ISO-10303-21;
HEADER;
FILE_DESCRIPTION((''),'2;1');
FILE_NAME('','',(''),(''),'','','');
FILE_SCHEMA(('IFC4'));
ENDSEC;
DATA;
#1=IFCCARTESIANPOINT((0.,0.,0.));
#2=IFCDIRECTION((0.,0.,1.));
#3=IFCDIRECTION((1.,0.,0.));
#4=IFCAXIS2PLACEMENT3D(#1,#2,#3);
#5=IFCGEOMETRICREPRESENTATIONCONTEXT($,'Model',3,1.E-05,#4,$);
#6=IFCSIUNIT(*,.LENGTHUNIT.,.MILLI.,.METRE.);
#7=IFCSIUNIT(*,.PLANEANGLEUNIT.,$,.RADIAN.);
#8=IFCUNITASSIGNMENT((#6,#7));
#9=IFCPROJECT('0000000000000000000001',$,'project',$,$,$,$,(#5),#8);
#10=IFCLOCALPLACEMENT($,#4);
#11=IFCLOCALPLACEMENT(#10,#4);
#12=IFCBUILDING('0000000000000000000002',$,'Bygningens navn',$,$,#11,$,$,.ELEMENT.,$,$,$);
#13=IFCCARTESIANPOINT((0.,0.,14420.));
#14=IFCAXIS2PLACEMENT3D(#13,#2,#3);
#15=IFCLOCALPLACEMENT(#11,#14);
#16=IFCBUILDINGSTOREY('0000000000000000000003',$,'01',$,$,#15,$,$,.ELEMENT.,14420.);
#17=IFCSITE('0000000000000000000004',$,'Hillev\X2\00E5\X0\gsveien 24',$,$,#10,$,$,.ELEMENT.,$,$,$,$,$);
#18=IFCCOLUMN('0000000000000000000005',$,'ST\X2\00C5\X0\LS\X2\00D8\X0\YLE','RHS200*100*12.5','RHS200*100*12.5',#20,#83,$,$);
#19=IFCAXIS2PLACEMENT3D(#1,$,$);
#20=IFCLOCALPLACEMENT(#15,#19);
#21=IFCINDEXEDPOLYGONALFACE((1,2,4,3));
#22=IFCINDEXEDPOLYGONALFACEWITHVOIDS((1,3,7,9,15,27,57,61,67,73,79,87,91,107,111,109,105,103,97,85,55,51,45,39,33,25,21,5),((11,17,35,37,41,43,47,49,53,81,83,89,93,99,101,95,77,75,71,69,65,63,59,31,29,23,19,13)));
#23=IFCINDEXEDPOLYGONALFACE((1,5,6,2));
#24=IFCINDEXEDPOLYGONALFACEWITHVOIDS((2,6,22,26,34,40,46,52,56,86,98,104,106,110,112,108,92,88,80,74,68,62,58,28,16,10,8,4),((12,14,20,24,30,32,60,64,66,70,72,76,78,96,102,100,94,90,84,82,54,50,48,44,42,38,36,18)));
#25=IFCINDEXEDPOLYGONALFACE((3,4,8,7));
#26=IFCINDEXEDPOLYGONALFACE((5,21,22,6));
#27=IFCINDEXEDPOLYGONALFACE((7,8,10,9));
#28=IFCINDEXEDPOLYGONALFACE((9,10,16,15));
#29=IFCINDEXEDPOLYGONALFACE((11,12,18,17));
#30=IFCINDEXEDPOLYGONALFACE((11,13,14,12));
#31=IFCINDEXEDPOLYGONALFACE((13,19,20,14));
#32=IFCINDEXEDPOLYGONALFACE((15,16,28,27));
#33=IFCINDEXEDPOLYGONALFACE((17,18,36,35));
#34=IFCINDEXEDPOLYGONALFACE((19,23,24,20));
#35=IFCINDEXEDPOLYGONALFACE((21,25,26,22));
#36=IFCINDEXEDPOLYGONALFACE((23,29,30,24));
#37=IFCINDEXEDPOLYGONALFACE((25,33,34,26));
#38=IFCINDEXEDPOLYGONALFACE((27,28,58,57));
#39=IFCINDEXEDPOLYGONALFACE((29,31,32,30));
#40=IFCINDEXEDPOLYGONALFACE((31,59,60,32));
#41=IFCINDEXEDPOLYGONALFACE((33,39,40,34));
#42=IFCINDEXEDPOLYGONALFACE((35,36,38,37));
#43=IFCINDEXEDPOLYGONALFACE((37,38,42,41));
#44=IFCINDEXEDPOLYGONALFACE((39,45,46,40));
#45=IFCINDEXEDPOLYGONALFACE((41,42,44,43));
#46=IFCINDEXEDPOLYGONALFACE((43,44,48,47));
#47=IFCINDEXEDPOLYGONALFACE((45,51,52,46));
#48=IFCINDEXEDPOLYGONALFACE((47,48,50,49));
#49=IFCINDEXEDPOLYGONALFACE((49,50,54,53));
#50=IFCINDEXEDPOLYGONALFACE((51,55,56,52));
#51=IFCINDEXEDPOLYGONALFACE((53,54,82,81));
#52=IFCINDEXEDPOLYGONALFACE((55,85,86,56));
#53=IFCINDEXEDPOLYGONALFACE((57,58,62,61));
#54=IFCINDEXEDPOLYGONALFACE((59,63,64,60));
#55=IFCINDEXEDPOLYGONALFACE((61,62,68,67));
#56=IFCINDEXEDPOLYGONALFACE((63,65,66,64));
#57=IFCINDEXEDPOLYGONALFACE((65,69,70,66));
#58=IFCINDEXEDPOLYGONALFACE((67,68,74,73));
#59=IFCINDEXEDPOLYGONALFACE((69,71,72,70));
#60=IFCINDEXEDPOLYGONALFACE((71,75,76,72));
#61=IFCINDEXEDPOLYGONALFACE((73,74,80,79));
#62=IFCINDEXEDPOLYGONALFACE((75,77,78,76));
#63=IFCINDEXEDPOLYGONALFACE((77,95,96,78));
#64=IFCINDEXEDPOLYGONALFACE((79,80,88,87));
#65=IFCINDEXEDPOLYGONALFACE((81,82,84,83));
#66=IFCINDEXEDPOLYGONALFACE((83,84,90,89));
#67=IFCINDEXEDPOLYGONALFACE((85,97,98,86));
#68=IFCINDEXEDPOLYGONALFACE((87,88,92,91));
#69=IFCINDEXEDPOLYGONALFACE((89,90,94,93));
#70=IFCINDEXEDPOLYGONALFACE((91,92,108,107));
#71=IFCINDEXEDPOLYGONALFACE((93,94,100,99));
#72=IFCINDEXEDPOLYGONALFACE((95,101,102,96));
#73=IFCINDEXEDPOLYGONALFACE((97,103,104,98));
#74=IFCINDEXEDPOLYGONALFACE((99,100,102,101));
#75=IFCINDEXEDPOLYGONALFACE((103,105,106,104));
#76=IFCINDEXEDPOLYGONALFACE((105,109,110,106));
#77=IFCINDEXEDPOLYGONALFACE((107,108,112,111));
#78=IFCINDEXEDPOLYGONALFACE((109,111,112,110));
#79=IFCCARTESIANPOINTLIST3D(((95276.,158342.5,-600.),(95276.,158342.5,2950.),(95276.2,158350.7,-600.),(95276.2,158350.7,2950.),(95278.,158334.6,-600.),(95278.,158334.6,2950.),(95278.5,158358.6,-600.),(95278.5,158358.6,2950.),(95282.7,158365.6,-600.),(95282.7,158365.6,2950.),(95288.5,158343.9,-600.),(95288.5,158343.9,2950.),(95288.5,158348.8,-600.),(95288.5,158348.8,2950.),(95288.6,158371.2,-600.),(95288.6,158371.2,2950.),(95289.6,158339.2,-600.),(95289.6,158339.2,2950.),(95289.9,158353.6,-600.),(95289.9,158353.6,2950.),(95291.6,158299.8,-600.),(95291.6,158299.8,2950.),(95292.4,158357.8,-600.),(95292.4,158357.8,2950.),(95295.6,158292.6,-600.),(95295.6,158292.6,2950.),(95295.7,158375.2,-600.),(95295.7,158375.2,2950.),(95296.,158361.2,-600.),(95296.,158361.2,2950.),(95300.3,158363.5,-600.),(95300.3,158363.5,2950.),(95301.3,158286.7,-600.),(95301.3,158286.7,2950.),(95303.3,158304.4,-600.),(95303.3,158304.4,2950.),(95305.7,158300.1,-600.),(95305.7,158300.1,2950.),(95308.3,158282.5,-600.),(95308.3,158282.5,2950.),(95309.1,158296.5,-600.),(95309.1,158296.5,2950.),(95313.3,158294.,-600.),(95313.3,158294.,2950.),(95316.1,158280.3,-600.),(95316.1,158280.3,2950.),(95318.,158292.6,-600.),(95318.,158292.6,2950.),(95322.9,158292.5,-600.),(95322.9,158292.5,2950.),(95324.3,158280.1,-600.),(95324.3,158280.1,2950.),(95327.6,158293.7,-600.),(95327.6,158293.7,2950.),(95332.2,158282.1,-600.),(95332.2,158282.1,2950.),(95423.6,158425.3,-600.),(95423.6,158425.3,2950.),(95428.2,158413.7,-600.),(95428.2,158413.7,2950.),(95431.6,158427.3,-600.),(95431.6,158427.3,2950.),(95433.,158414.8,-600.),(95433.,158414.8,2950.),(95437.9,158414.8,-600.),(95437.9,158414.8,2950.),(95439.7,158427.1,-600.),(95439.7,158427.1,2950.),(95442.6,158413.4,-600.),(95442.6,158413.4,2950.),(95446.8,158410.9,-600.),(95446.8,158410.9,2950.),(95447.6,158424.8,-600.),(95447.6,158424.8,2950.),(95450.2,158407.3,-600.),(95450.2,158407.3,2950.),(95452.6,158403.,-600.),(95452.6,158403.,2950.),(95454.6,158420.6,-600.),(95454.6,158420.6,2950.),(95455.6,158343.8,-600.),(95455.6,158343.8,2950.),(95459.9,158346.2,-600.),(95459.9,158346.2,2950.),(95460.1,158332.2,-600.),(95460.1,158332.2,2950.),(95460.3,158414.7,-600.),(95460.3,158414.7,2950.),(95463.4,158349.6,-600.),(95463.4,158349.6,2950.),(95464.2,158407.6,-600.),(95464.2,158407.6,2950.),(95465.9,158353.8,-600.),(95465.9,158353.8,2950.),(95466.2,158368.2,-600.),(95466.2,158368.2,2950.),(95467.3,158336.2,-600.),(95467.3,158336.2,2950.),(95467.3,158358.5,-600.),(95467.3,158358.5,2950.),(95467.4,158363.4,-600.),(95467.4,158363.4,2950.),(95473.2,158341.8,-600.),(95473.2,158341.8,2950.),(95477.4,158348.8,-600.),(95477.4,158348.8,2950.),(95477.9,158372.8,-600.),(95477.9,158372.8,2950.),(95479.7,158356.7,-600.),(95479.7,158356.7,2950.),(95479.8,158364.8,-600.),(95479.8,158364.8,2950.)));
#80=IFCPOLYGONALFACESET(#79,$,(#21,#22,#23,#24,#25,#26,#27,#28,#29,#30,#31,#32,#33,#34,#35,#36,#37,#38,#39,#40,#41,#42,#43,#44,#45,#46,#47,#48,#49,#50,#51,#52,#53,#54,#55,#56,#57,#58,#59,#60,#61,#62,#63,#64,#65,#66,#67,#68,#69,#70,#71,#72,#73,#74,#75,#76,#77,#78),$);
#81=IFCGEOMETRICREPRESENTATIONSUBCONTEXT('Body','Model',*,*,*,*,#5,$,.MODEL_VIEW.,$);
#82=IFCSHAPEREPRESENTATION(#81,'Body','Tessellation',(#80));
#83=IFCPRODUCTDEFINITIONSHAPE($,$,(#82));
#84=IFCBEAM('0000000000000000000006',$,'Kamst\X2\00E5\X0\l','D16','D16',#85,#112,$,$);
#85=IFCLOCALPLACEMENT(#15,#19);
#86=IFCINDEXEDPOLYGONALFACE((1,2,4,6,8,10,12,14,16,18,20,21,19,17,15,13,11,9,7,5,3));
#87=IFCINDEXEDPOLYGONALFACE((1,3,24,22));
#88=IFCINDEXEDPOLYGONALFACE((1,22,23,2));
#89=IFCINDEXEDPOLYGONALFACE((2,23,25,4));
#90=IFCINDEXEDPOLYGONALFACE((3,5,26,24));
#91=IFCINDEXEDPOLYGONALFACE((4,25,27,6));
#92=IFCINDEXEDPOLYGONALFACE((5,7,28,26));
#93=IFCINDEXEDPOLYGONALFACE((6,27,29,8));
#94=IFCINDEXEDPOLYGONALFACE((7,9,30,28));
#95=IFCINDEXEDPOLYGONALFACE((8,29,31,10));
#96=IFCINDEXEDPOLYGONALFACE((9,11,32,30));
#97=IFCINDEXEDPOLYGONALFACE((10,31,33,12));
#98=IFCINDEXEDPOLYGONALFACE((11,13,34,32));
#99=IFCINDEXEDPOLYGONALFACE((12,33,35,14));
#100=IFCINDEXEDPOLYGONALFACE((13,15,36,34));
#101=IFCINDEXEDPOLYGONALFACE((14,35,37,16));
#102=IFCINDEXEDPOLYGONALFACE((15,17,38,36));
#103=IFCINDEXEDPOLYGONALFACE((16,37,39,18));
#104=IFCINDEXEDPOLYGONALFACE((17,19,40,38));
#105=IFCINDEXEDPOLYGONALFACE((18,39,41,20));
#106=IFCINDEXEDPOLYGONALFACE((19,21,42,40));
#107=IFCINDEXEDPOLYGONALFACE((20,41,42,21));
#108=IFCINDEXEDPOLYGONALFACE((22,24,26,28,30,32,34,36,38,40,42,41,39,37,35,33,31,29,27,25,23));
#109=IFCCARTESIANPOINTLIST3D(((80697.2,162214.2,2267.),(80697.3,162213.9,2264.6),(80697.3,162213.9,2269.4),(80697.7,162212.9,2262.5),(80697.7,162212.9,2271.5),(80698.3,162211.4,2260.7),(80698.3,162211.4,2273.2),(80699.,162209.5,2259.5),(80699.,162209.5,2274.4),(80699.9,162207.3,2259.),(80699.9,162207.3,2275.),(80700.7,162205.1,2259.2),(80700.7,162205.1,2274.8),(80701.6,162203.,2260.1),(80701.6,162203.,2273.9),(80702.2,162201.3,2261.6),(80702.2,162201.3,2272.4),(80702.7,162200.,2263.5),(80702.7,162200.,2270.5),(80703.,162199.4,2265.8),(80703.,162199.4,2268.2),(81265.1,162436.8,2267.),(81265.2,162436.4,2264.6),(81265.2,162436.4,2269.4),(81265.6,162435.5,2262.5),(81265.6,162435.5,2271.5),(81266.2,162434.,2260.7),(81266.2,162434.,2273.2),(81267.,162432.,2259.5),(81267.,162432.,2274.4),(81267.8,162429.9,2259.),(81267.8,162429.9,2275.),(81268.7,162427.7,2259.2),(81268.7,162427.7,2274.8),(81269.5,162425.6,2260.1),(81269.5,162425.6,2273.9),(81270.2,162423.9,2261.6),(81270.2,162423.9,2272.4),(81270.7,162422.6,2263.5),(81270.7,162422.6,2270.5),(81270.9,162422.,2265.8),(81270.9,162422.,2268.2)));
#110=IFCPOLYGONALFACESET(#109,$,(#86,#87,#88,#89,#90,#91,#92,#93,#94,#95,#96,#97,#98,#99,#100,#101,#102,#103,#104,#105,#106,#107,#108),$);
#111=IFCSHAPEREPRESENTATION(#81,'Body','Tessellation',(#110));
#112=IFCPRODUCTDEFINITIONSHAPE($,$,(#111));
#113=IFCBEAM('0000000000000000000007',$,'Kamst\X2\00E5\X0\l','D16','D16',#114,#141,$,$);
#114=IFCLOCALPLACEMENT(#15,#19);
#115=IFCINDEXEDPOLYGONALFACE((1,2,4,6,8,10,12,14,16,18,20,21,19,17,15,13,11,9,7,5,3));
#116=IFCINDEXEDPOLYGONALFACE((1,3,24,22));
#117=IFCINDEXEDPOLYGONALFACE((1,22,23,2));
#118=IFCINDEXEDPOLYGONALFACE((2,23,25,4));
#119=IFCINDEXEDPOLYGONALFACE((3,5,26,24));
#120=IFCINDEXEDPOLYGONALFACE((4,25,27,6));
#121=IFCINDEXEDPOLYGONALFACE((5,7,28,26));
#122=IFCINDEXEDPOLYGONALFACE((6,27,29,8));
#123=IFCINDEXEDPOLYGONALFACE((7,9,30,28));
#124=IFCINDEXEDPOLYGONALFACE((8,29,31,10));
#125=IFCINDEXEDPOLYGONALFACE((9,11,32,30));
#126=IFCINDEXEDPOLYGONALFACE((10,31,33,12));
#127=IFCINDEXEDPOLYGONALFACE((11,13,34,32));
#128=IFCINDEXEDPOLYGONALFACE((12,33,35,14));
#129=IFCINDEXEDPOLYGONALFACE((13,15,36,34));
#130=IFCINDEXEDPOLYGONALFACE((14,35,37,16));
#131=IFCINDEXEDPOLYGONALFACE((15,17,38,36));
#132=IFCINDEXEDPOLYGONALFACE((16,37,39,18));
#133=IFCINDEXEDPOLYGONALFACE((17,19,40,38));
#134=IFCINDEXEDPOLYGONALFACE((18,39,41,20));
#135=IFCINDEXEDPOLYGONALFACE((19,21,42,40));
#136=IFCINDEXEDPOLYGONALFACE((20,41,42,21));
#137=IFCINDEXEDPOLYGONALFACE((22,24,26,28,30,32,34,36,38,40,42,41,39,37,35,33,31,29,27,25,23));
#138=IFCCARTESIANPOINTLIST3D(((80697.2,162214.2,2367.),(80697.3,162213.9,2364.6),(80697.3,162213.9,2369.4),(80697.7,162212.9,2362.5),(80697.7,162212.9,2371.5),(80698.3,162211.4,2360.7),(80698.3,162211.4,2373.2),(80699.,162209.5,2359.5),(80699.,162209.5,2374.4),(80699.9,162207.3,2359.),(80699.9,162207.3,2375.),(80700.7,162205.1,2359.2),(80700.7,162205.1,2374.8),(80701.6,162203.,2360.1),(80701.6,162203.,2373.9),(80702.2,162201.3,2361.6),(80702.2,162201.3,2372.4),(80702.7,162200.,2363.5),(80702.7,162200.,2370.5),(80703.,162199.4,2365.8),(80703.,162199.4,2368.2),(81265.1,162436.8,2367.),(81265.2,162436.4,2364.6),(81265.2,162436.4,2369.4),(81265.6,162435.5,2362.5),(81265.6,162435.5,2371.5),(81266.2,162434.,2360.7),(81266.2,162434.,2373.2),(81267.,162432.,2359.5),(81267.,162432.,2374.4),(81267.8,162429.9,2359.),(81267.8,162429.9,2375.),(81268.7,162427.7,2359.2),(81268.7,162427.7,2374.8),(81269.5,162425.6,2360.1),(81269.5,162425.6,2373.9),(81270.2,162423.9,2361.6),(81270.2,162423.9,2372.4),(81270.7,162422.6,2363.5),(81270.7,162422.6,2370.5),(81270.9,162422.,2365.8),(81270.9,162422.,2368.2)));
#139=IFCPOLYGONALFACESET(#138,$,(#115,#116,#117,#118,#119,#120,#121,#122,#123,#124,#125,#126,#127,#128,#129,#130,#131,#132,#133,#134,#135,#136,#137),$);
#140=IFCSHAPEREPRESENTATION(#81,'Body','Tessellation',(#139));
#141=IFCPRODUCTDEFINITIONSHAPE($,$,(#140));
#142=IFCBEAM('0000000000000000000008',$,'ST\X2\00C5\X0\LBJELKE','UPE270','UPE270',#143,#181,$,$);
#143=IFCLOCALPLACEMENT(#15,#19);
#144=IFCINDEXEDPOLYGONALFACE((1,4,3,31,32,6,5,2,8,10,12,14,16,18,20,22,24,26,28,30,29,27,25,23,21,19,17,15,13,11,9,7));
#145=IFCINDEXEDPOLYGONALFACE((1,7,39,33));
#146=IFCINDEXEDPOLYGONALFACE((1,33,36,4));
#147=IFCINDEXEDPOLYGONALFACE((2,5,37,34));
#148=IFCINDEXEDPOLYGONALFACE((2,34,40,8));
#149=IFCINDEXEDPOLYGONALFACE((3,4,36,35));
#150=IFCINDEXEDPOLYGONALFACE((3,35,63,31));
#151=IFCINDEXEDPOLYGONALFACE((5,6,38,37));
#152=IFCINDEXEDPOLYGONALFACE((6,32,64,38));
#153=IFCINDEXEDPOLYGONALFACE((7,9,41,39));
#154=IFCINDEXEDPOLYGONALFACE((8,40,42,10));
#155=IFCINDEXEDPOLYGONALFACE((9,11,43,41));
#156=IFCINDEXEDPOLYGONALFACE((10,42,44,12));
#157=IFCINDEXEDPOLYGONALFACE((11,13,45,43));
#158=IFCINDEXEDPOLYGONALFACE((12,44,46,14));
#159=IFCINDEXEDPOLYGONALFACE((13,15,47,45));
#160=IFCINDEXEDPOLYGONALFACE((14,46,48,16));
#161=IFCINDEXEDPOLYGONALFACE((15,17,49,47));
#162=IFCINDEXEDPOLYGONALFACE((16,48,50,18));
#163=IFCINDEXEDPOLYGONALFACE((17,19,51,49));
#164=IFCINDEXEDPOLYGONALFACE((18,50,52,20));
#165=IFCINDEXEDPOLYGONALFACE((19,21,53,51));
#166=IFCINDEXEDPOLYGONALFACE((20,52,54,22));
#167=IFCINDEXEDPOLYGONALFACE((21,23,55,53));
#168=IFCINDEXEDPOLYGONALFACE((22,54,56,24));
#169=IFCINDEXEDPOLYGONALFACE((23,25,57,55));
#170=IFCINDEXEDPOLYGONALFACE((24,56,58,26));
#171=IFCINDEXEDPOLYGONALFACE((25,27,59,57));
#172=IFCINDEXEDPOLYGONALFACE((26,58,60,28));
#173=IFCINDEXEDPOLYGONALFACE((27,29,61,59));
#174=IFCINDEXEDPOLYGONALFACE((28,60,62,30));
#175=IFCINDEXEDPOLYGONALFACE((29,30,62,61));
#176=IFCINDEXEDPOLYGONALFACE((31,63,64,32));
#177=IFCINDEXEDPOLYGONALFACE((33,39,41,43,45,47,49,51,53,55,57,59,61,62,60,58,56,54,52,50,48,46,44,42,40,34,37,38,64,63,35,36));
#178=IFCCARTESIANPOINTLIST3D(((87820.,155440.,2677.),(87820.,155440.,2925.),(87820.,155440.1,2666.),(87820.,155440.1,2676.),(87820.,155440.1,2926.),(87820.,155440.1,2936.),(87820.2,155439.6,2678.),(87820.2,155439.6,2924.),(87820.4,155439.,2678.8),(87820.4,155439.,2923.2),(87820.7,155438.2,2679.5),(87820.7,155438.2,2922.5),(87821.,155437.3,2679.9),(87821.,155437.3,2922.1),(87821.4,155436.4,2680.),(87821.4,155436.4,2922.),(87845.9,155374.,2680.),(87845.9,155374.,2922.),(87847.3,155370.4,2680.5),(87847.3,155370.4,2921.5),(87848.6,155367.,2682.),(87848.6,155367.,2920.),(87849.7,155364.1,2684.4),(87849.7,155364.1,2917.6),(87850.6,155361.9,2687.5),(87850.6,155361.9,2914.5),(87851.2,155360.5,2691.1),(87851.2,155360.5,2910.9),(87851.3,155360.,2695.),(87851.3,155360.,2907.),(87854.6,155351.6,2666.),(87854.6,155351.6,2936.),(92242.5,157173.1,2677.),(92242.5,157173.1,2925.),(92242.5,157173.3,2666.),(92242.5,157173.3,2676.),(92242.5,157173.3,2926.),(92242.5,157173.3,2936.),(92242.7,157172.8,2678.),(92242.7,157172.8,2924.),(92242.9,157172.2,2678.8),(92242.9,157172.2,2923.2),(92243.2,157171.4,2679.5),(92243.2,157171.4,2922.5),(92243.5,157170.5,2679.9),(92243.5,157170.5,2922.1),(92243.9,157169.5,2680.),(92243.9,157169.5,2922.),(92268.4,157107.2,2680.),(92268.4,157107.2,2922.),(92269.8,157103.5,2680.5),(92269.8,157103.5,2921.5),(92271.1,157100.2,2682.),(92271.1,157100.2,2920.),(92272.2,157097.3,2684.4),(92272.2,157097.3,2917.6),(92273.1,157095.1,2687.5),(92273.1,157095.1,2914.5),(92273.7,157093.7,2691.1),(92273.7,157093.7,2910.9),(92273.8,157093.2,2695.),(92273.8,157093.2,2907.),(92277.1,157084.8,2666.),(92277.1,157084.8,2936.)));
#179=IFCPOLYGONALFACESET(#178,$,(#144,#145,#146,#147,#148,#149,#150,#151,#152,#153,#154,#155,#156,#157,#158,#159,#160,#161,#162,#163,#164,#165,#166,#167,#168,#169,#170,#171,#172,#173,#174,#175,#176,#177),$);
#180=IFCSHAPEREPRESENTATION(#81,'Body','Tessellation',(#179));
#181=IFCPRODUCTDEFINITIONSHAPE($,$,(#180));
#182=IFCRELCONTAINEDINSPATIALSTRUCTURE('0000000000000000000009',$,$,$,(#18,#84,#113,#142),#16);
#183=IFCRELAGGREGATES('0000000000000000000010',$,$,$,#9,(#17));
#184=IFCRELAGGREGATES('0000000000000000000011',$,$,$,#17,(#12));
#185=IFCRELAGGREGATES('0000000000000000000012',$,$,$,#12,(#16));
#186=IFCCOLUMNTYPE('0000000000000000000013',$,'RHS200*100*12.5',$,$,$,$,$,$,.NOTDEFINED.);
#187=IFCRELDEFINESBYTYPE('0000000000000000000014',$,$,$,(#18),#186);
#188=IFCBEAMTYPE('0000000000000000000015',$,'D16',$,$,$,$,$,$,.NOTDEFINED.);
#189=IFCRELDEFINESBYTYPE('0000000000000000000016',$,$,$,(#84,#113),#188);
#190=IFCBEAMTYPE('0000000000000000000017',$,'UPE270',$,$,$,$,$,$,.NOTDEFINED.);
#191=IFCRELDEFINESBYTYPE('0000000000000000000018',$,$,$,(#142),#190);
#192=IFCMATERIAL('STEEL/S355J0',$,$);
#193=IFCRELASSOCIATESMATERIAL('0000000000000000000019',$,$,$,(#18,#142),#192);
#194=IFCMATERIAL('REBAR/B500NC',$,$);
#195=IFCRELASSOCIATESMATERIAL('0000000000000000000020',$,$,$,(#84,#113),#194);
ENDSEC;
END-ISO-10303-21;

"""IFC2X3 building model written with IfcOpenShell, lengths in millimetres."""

from ifc_helpers import new_model, si_unit, frame, frame_2d, origin_with_axes, place, context, subcontext, project, spatial, hollow_rectangle, circle, u_section, extrude, material, type_object, element, save


model = new_model("IFC2X3")

# Units and contexts
model_context = context("Model", 3, precision=1e-05, world=origin_with_axes())
body_context = subcontext(model_context, "Body", "Model", "MODEL_VIEW")
ifc_project = project(units=[si_unit("LENGTHUNIT", "METRE", prefix="MILLI"), si_unit("PLANEANGLEUNIT", "RADIAN")], contexts=[model_context])

# Site, building, storey
site_placement = place(None, origin_with_axes())
site = spatial("IfcSite", under=ifc_project, at=site_placement, Name="Hillevågsveien 24", CompositionType="ELEMENT")
building_placement = place(site_placement, origin_with_axes())
building = spatial("IfcBuilding", under=site, at=building_placement, Name="Bygningens navn", CompositionType="ELEMENT")
storey_placement = place(building_placement, frame((0.0, 0.0, 14420.0), z_axis=(0.0, 0.0, 1.0), x_axis=(1.0, 0.0, 0.0)))
storey = spatial("IfcBuildingStorey", under=building, at=storey_placement, Name="01", CompositionType="ELEMENT", Elevation=14420.0)

# Column
ifc_material_1 = material(Name="STEEL/S355J0")
column_type = type_object("IfcColumnType", Name="RHS200*100*12.5", PredefinedType="NOTDEFINED")
column_1_placement = place(storey_placement, frame((95377.9, 158353.7, -600.0), z_axis=(0.0, 0.0, 1.0), x_axis=(0.931056, 0.364877, 0.0)))
element("IfcColumn", 1, at=column_1_placement, inside=storey, type_object=column_type, material=ifc_material_1, Name="STÅLSØYLE", Description="RHS200*100*12.5", ObjectType="RHS200*100*12.5", context=body_context, shape_type="SweptSolid", body=[
    extrude(hollow_rectangle(XDim=100.0, YDim=200.0, WallThickness=12.5, InnerFilletRadius=18.8, OuterFilletRadius=31.3, at=frame_2d((0.0, 0.0), x_axis=(1.0, 0.0))), frame((0.0, 0.0, 3550.0), z_axis=(0.0, 0.0, -1.0), x_axis=(0.0, 1.0, 0.0)), (0.0, 0.0, 1.0), 3550.0),
])

# Beams
ifc_material_2 = material(Name="REBAR/B500NC")
beam_type_1 = type_object("IfcBeamType", Name="D16", PredefinedType="NOTDEFINED")
for number, where, z_axis, x_axis, name in (
    (2, (80700.1, 162206.7, 2267.0), (0.0, 0.0, -1.0), (0.931055, 0.364878, 0.0), "Kamstål"),
    (3, (80700.1, 162206.7, 2367.0), (0.0, 0.0, -1.0), (0.931055, 0.364878, 0.0), "Kamstål"),
):
    element("IfcBeam", number, at=place(storey_placement, frame(where, z_axis=z_axis, x_axis=x_axis)), inside=storey, type_object=beam_type_1, material=ifc_material_2, Name=name, Description="D16", ObjectType="D16", context=body_context, shape_type="SweptSolid", body=[
        extrude(circle(Radius=8.0, at=frame_2d((0.0, 0.0), x_axis=(1.0, 0.0))), frame((610.0, 0.0, 0.0), z_axis=(-1.0, 0.0, 0.0), x_axis=(0.0, -1.0, 0.0)), (0.0, 0.0, 1.0), 610.0),
    ])
beam_type_2 = type_object("IfcBeamType", Name="UPE270", PredefinedType="NOTDEFINED")
beam_1_placement = place(storey_placement, frame((87837.3, 155395.9, 2801.0), z_axis=(0.0, 0.0, -1.0), x_axis=(0.931055, 0.36488, 0.0)))
element("IfcBeam", 4, at=beam_1_placement, inside=storey, type_object=beam_type_2, material=ifc_material_1, Name="STÅLBJELKE", Description="UPE270", ObjectType="UPE270", context=body_context, shape_type="SweptSolid", body=[
    extrude(u_section(Depth=270.0, FlangeWidth=95.0, WebThickness=9.0, FlangeThickness=14.0, FilletRadius=15.0, EdgeRadius=4.0, at=frame_2d((0.0, 0.0), x_axis=(1.0, 0.0))), frame((4750.0, 0.0, 0.0), z_axis=(-1.0, 0.0, 0.0), x_axis=(0.0, -1.0, 0.0)), (0.0, 0.0, 1.0), 4750.0),
])

save(model, "model.ifc")
